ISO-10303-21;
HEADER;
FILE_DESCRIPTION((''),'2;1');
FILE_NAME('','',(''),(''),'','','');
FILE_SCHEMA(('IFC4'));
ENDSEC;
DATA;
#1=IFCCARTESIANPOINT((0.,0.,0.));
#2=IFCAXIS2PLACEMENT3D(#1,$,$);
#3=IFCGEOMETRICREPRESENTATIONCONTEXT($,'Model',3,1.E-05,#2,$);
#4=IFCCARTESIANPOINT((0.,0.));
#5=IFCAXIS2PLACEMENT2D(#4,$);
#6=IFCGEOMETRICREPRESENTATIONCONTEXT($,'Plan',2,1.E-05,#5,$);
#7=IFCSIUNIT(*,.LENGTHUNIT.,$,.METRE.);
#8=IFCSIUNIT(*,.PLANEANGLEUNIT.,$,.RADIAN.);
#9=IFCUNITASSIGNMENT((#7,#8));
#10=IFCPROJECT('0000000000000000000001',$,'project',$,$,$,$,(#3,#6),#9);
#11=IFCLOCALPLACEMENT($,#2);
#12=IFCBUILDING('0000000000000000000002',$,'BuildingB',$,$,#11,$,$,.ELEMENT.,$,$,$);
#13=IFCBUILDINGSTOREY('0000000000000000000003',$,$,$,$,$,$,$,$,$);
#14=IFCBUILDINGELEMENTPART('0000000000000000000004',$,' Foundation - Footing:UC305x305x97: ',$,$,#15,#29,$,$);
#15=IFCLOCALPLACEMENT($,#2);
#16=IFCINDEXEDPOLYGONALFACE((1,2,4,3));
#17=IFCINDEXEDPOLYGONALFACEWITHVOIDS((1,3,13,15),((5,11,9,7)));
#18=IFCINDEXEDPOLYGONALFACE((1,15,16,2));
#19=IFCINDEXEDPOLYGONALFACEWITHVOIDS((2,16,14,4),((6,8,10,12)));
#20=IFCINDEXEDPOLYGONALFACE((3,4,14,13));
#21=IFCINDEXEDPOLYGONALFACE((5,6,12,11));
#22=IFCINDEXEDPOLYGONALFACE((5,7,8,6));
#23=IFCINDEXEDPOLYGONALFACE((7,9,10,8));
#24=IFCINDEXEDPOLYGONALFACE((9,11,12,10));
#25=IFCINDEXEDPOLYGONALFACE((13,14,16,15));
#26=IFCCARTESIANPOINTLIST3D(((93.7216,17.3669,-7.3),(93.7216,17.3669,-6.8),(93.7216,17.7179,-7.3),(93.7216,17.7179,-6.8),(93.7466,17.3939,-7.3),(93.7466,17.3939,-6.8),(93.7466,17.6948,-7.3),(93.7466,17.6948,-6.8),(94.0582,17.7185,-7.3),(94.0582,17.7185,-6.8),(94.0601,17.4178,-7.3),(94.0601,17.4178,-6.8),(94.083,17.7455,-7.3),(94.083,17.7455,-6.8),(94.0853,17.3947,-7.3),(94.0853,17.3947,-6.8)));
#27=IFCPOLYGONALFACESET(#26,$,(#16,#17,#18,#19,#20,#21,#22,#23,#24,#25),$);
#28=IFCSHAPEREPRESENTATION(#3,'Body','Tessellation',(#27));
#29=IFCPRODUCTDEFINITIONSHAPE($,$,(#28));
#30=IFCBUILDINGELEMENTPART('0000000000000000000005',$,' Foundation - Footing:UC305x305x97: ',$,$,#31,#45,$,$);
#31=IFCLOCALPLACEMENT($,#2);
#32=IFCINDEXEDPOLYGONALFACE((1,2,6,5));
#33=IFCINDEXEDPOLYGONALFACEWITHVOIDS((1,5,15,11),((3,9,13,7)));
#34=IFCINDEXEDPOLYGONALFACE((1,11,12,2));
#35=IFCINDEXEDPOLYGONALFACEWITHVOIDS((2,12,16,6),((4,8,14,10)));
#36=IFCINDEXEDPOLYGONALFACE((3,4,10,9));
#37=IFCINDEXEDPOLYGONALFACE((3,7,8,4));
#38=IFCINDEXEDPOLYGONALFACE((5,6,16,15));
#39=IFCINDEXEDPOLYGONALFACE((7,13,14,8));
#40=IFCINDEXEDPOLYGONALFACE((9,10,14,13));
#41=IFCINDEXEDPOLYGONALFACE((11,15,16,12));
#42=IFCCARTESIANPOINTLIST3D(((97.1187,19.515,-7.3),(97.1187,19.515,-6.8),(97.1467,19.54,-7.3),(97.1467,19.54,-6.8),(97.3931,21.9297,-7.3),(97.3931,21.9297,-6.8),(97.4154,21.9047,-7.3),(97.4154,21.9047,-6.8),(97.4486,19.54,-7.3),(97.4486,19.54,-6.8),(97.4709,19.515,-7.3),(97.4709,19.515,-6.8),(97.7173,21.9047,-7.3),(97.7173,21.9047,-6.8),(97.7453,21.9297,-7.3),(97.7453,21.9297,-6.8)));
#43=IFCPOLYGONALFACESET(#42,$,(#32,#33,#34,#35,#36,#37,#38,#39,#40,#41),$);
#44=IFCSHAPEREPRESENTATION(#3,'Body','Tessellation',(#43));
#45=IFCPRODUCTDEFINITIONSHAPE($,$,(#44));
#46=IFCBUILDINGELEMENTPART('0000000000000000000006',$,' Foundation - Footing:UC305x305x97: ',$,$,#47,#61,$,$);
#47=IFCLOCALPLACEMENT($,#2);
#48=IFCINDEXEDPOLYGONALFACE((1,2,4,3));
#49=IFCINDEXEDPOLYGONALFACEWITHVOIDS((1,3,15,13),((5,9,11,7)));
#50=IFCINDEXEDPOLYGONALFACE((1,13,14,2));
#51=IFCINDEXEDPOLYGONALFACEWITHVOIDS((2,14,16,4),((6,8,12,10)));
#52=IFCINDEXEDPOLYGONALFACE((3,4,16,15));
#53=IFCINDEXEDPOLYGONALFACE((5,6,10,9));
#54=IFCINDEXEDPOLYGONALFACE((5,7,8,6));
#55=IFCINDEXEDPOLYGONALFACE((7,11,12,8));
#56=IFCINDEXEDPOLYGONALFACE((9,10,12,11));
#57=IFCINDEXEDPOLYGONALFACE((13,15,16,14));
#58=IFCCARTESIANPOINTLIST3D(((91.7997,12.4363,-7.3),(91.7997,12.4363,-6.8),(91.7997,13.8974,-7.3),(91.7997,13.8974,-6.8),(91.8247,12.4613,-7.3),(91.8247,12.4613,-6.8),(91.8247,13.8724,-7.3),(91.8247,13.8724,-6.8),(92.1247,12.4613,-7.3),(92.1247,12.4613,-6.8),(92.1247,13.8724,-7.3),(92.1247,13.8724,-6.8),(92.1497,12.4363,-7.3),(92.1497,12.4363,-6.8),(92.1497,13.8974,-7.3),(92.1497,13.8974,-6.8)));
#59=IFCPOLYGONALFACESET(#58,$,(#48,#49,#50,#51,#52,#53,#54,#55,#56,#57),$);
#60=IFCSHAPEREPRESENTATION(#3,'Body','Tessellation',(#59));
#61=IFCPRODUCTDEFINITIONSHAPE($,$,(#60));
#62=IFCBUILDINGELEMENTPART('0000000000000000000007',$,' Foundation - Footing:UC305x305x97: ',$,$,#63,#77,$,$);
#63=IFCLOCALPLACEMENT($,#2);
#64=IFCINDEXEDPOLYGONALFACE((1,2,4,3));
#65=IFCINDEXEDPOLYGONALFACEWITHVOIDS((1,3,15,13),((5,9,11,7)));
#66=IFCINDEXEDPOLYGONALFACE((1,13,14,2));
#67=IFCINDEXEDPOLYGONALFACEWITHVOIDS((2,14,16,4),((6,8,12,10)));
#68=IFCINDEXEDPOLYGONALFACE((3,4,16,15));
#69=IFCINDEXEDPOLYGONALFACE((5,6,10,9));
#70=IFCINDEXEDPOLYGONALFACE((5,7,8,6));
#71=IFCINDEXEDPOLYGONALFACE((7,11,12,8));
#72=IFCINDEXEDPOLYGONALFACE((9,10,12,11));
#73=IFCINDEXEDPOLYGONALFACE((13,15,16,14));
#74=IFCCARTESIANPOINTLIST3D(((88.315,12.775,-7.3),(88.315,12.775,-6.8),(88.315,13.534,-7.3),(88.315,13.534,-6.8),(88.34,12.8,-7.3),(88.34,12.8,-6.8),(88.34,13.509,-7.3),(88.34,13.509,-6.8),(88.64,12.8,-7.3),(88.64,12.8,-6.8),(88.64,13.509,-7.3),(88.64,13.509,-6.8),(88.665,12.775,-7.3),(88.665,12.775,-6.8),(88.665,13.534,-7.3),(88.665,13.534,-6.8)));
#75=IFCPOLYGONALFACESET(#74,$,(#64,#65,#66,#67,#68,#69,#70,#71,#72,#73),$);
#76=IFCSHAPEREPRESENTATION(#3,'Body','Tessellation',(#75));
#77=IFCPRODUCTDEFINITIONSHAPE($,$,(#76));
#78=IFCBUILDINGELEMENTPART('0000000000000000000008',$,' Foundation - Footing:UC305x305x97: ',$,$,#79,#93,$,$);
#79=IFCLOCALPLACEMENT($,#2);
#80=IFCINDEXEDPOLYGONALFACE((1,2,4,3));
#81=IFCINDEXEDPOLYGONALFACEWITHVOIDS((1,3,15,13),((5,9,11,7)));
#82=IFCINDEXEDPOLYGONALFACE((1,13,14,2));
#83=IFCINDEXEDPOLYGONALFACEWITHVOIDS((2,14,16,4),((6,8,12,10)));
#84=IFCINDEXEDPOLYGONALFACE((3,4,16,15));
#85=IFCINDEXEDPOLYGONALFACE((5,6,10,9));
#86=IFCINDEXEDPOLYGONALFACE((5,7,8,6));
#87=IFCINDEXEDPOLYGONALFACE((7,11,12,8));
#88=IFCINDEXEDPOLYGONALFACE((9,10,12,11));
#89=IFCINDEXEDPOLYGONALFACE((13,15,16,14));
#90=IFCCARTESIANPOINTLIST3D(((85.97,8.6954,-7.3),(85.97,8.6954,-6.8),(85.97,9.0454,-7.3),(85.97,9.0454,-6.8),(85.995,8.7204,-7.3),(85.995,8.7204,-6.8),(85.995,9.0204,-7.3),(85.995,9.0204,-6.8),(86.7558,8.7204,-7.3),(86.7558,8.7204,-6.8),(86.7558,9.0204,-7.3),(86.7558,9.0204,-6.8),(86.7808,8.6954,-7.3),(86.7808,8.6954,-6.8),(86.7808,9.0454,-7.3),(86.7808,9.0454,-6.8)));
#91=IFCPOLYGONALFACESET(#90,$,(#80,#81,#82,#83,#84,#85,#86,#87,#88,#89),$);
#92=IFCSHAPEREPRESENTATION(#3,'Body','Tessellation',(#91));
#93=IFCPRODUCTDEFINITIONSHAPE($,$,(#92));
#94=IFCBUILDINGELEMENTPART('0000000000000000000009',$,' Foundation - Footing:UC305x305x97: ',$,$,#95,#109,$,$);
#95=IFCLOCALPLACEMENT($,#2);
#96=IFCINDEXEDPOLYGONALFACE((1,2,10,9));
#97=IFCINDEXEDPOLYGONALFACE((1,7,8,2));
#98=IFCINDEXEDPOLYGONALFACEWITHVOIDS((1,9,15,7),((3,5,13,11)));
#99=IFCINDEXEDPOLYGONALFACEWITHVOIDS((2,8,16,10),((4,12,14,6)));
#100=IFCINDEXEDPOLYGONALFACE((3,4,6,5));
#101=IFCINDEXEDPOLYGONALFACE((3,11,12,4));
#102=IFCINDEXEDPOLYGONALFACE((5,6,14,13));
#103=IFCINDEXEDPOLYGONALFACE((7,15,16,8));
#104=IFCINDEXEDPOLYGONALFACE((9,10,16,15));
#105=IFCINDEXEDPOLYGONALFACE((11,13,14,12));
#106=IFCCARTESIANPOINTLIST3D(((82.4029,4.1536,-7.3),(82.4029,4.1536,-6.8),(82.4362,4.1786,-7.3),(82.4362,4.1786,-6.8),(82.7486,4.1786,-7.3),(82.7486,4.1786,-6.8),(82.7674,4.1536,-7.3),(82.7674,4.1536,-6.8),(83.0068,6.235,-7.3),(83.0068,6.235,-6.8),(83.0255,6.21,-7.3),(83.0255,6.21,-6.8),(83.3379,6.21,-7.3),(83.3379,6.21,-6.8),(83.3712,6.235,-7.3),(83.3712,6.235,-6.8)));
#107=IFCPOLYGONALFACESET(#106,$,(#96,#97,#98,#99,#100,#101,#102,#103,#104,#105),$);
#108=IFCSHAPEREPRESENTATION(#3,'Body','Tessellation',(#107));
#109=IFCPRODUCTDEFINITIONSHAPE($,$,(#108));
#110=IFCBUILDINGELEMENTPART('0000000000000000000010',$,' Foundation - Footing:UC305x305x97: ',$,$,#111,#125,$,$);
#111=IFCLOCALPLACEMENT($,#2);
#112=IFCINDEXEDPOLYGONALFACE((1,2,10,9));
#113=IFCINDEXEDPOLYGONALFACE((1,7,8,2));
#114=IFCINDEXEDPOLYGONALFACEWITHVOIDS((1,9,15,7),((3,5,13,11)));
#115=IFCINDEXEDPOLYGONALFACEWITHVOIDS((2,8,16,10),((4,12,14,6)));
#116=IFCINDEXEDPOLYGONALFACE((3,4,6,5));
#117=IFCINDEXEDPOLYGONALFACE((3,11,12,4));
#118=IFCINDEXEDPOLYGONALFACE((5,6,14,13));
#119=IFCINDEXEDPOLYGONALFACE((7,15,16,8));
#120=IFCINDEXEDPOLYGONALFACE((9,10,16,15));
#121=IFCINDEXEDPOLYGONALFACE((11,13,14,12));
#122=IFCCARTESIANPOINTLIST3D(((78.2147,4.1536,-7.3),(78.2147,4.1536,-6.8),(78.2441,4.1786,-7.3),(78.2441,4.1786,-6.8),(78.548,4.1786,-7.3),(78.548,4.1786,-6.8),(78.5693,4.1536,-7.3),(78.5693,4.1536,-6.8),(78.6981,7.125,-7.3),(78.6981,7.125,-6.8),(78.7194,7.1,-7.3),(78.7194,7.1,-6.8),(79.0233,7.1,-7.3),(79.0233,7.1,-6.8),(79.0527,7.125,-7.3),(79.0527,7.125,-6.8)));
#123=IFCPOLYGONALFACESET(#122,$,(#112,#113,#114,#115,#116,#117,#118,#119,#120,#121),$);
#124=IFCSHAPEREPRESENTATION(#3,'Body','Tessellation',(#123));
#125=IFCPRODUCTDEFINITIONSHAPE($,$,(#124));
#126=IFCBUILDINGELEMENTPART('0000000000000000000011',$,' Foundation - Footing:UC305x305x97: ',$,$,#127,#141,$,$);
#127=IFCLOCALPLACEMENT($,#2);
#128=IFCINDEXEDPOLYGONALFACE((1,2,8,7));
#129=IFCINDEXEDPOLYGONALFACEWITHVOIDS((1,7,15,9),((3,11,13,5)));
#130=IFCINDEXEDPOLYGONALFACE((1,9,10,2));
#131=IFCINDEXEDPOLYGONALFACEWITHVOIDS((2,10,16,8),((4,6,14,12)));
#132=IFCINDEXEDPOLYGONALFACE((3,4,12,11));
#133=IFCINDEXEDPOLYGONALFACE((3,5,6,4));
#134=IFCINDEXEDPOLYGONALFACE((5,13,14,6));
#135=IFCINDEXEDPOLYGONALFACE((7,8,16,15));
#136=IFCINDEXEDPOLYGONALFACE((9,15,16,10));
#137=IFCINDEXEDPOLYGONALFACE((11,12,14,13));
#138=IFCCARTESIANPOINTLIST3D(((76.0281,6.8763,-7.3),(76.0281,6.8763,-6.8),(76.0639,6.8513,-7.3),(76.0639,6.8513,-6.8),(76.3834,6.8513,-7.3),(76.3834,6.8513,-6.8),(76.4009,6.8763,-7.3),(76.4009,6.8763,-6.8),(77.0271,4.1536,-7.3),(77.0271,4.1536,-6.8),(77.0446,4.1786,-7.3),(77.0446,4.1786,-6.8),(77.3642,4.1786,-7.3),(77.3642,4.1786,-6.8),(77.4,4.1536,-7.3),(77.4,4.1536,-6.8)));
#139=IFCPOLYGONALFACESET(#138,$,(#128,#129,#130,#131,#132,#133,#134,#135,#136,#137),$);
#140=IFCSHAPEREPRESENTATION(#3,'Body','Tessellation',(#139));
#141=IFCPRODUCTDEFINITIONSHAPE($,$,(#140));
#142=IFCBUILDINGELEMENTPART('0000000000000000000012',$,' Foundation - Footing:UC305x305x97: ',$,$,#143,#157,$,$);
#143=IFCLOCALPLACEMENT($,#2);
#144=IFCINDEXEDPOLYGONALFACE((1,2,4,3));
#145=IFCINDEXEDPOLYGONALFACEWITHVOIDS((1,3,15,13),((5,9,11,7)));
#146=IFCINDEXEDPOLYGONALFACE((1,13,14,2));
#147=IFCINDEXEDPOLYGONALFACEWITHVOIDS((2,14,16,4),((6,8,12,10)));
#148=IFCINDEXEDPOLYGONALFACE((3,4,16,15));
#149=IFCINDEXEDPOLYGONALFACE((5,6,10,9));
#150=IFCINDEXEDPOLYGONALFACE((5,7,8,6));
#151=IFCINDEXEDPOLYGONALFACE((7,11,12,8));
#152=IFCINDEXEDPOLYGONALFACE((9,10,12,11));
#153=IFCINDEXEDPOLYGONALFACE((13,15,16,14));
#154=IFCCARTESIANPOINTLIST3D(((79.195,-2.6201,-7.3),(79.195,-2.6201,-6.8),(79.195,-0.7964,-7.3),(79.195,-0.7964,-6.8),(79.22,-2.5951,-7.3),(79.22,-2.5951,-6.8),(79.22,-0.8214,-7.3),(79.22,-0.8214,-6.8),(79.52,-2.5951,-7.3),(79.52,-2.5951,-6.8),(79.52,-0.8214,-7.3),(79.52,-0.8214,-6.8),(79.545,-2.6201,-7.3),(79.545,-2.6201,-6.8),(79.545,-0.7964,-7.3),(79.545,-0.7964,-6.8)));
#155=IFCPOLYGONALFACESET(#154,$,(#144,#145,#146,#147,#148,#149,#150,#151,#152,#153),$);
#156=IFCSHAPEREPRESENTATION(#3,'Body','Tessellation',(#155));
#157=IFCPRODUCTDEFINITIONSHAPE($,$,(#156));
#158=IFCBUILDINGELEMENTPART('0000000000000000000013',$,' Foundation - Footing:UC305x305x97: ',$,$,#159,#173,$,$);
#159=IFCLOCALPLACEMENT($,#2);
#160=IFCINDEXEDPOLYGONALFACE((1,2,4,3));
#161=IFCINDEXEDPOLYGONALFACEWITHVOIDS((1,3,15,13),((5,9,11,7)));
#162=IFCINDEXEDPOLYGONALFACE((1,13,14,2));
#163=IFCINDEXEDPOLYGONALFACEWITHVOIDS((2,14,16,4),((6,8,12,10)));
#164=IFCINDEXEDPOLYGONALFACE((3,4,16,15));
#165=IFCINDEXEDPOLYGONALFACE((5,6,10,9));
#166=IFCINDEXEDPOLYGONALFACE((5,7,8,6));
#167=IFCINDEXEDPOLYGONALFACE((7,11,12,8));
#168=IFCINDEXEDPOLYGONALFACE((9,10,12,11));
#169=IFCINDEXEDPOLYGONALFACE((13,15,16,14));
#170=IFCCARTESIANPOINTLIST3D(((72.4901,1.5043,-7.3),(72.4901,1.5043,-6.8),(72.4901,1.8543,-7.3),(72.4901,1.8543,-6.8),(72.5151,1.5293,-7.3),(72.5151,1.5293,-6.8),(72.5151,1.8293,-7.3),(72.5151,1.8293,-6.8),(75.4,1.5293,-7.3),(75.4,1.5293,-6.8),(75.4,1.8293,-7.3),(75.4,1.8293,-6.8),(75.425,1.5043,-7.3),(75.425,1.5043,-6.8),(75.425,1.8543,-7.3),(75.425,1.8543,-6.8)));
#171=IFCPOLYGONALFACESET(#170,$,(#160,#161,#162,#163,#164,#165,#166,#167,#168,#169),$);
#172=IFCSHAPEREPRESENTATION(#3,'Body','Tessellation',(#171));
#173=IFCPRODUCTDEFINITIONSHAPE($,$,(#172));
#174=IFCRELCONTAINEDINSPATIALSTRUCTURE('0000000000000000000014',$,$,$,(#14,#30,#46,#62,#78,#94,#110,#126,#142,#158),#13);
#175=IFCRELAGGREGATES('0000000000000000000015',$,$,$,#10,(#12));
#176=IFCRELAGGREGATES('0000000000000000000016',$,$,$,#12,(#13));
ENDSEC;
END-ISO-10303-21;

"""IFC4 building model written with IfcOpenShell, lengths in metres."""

from ifc_helpers import new_model, si_unit, origin, origin_2d, place, context, project, spatial, polyline, outline, extrude, element, save


model = new_model("IFC4")

# Units and contexts
model_context = context("Model", 3, precision=1e-05, world=origin())
plan_context = context("Plan", 2, precision=1e-05, world=origin_2d())
ifc_project = project(units=[si_unit("LENGTHUNIT", "METRE"), si_unit("PLANEANGLEUNIT", "RADIAN")], contexts=[model_context, plan_context])

# Building, storey
building_placement = place(None, origin())
building = spatial("IfcBuilding", under=ifc_project, at=building_placement, Name="BuildingB", CompositionType="ELEMENT")
storey = spatial("IfcBuildingStorey", under=building)

# Building element parts, openings
building_element_part_1 = element("IfcBuildingElementPart", 1, inside=storey, Name=" Foundation - Footing:UC305x305x97: ", context=model_context, shape_type="SweptSolid", body=[
    extrude(outline(polyline([(94.0853, 17.3947, -7.3), (93.7216, 17.3669, -7.3), (93.7216, 17.7179, -7.3), (94.083, 17.7455, -7.3), (94.0853, 17.3947, -7.3)])), None, (0.0, 0.0, 1.0), 0.5),
])
element("IfcOpeningElement", 2, inside=storey, cuts=building_element_part_1, context=model_context, shape_type="SweptSolid", body=[
    extrude(outline(polyline([(94.0601, 17.4178, -7.3), (93.7466, 17.3939, -7.3), (93.7466, 17.6948, -7.3), (94.0582, 17.7185, -7.3), (94.0601, 17.4178, -7.3)])), None, (0.0, 0.0, 1.0), 0.5),
])
building_element_part_2 = element("IfcBuildingElementPart", 3, inside=storey, Name=" Foundation - Footing:UC305x305x97: ", context=model_context, shape_type="SweptSolid", body=[
    extrude(outline(polyline([(97.4709, 19.515, -7.3), (97.1187, 19.515, -7.3), (97.3931, 21.9297, -7.3), (97.7453, 21.9297, -7.3), (97.4709, 19.515, -7.3)])), None, (0.0, 0.0, 1.0), 0.5),
])
element("IfcOpeningElement", 4, inside=storey, cuts=building_element_part_2, context=model_context, shape_type="SweptSolid", body=[
    extrude(outline(polyline([(97.4486, 19.54, -7.3), (97.1467, 19.54, -7.3), (97.4154, 21.9047, -7.3), (97.7173, 21.9047, -7.3), (97.4486, 19.54, -7.3)])), None, (0.0, 0.0, 1.0), 0.5),
])
building_element_part_3 = element("IfcBuildingElementPart", 5, inside=storey, Name=" Foundation - Footing:UC305x305x97: ", context=model_context, shape_type="SweptSolid", body=[
    extrude(outline(polyline([(92.1497, 12.4363, -7.3), (91.7997, 12.4363, -7.3), (91.7997, 13.8974, -7.3), (92.1497, 13.8974, -7.3), (92.1497, 12.4363, -7.3)])), None, (0.0, 0.0, 1.0), 0.5),
])
element("IfcOpeningElement", 6, inside=storey, cuts=building_element_part_3, context=model_context, shape_type="SweptSolid", body=[
    extrude(outline(polyline([(92.1247, 12.4613, -7.3), (91.8247, 12.4613, -7.3), (91.8247, 13.8724, -7.3), (92.1247, 13.8724, -7.3), (92.1247, 12.4613, -7.3)])), None, (0.0, 0.0, 1.0), 0.5),
])
building_element_part_4 = element("IfcBuildingElementPart", 7, inside=storey, Name=" Foundation - Footing:UC305x305x97: ", context=model_context, shape_type="SweptSolid", body=[
    extrude(outline(polyline([(88.665, 12.775, -7.3), (88.315, 12.775, -7.3), (88.315, 13.534, -7.3), (88.665, 13.534, -7.3), (88.665, 12.775, -7.3)])), None, (0.0, 0.0, 1.0), 0.5),
])
element("IfcOpeningElement", 8, inside=storey, cuts=building_element_part_4, context=model_context, shape_type="SweptSolid", body=[
    extrude(outline(polyline([(88.64, 12.8, -7.3), (88.34, 12.8, -7.3), (88.34, 13.509, -7.3), (88.64, 13.509, -7.3), (88.64, 12.8, -7.3)])), None, (0.0, 0.0, 1.0), 0.5),
])
building_element_part_5 = element("IfcBuildingElementPart", 9, inside=storey, Name=" Foundation - Footing:UC305x305x97: ", context=model_context, shape_type="SweptSolid", body=[
    extrude(outline(polyline([(86.7808, 8.6954, -7.3), (85.97, 8.6954, -7.3), (85.97, 9.0454, -7.3), (86.7808, 9.0454, -7.3), (86.7808, 8.6954, -7.3)])), None, (0.0, 0.0, 1.0), 0.5),
])
element("IfcOpeningElement", 10, inside=storey, cuts=building_element_part_5, context=model_context, shape_type="SweptSolid", body=[
    extrude(outline(polyline([(86.7558, 8.7204, -7.3), (85.995, 8.7204, -7.3), (85.995, 9.0204, -7.3), (86.7558, 9.0204, -7.3), (86.7558, 8.7204, -7.3)])), None, (0.0, 0.0, 1.0), 0.5),
])
building_element_part_6 = element("IfcBuildingElementPart", 11, inside=storey, Name=" Foundation - Footing:UC305x305x97: ", context=model_context, shape_type="SweptSolid", body=[
    extrude(outline(polyline([(82.7674, 4.1536, -7.3), (82.4029, 4.1536, -7.3), (83.0068, 6.235, -7.3), (83.3712, 6.235, -7.3), (82.7674, 4.1536, -7.3)])), None, (0.0, 0.0, 1.0), 0.5),
])
element("IfcOpeningElement", 12, inside=storey, cuts=building_element_part_6, context=model_context, shape_type="SweptSolid", body=[
    extrude(outline(polyline([(82.7486, 4.1786, -7.3), (82.4362, 4.1786, -7.3), (83.0255, 6.21, -7.3), (83.3379, 6.21, -7.3), (82.7486, 4.1786, -7.3)])), None, (0.0, 0.0, 1.0), 0.5),
])
building_element_part_7 = element("IfcBuildingElementPart", 13, inside=storey, Name=" Foundation - Footing:UC305x305x97: ", context=model_context, shape_type="SweptSolid", body=[
    extrude(outline(polyline([(78.5693, 4.1536, -7.3), (78.2147, 4.1536, -7.3), (78.6981, 7.125, -7.3), (79.0527, 7.125, -7.3), (78.5693, 4.1536, -7.3)])), None, (0.0, 0.0, 1.0), 0.5),
])
element("IfcOpeningElement", 14, inside=storey, cuts=building_element_part_7, context=model_context, shape_type="SweptSolid", body=[
    extrude(outline(polyline([(78.548, 4.1786, -7.3), (78.2441, 4.1786, -7.3), (78.7194, 7.1, -7.3), (79.0233, 7.1, -7.3), (78.548, 4.1786, -7.3)])), None, (0.0, 0.0, 1.0), 0.5),
])
building_element_part_8 = element("IfcBuildingElementPart", 15, inside=storey, Name=" Foundation - Footing:UC305x305x97: ", context=model_context, shape_type="SweptSolid", body=[
    extrude(outline(polyline([(77.4, 4.1536, -7.3), (77.0271, 4.1536, -7.3), (76.0281, 6.8763, -7.3), (76.4009, 6.8763, -7.3), (77.4, 4.1536, -7.3)])), None, (0.0, 0.0, 1.0), 0.5),
])
element("IfcOpeningElement", 16, inside=storey, cuts=building_element_part_8, context=model_context, shape_type="SweptSolid", body=[
    extrude(outline(polyline([(77.3642, 4.1786, -7.3), (77.0446, 4.1786, -7.3), (76.0639, 6.8513, -7.3), (76.3834, 6.8513, -7.3), (77.3642, 4.1786, -7.3)])), None, (0.0, 0.0, 1.0), 0.5),
])
building_element_part_9 = element("IfcBuildingElementPart", 17, inside=storey, Name=" Foundation - Footing:UC305x305x97: ", context=model_context, shape_type="SweptSolid", body=[
    extrude(outline(polyline([(79.545, -2.6201, -7.3), (79.195, -2.6201, -7.3), (79.195, -0.7964, -7.3), (79.545, -0.7964, -7.3), (79.545, -2.6201, -7.3)])), None, (0.0, 0.0, 1.0), 0.5),
])
element("IfcOpeningElement", 18, inside=storey, cuts=building_element_part_9, context=model_context, shape_type="SweptSolid", body=[
    extrude(outline(polyline([(79.52, -2.5951, -7.3), (79.22, -2.5951, -7.3), (79.22, -0.8214, -7.3), (79.52, -0.8214, -7.3), (79.52, -2.5951, -7.3)])), None, (0.0, 0.0, 1.0), 0.5),
])
building_element_part_10 = element("IfcBuildingElementPart", 19, inside=storey, Name=" Foundation - Footing:UC305x305x97: ", context=model_context, shape_type="SweptSolid", body=[
    extrude(outline(polyline([(75.425, 1.5043, -7.3), (75.425, 1.8543, -7.3), (72.4901, 1.8543, -7.3), (72.4901, 1.5043, -7.3), (75.425, 1.5043, -7.3)])), None, (0.0, 0.0, 1.0), 0.5),
])
element("IfcOpeningElement", 20, inside=storey, cuts=building_element_part_10, context=model_context, shape_type="SweptSolid", body=[
    extrude(outline(polyline([(75.4, 1.5293, -7.3), (75.4, 1.8293, -7.3), (72.5151, 1.8293, -7.3), (72.5151, 1.5293, -7.3), (75.4, 1.5293, -7.3)])), None, (0.0, 0.0, 1.0), 0.5),
])

save(model, "model.ifc")
